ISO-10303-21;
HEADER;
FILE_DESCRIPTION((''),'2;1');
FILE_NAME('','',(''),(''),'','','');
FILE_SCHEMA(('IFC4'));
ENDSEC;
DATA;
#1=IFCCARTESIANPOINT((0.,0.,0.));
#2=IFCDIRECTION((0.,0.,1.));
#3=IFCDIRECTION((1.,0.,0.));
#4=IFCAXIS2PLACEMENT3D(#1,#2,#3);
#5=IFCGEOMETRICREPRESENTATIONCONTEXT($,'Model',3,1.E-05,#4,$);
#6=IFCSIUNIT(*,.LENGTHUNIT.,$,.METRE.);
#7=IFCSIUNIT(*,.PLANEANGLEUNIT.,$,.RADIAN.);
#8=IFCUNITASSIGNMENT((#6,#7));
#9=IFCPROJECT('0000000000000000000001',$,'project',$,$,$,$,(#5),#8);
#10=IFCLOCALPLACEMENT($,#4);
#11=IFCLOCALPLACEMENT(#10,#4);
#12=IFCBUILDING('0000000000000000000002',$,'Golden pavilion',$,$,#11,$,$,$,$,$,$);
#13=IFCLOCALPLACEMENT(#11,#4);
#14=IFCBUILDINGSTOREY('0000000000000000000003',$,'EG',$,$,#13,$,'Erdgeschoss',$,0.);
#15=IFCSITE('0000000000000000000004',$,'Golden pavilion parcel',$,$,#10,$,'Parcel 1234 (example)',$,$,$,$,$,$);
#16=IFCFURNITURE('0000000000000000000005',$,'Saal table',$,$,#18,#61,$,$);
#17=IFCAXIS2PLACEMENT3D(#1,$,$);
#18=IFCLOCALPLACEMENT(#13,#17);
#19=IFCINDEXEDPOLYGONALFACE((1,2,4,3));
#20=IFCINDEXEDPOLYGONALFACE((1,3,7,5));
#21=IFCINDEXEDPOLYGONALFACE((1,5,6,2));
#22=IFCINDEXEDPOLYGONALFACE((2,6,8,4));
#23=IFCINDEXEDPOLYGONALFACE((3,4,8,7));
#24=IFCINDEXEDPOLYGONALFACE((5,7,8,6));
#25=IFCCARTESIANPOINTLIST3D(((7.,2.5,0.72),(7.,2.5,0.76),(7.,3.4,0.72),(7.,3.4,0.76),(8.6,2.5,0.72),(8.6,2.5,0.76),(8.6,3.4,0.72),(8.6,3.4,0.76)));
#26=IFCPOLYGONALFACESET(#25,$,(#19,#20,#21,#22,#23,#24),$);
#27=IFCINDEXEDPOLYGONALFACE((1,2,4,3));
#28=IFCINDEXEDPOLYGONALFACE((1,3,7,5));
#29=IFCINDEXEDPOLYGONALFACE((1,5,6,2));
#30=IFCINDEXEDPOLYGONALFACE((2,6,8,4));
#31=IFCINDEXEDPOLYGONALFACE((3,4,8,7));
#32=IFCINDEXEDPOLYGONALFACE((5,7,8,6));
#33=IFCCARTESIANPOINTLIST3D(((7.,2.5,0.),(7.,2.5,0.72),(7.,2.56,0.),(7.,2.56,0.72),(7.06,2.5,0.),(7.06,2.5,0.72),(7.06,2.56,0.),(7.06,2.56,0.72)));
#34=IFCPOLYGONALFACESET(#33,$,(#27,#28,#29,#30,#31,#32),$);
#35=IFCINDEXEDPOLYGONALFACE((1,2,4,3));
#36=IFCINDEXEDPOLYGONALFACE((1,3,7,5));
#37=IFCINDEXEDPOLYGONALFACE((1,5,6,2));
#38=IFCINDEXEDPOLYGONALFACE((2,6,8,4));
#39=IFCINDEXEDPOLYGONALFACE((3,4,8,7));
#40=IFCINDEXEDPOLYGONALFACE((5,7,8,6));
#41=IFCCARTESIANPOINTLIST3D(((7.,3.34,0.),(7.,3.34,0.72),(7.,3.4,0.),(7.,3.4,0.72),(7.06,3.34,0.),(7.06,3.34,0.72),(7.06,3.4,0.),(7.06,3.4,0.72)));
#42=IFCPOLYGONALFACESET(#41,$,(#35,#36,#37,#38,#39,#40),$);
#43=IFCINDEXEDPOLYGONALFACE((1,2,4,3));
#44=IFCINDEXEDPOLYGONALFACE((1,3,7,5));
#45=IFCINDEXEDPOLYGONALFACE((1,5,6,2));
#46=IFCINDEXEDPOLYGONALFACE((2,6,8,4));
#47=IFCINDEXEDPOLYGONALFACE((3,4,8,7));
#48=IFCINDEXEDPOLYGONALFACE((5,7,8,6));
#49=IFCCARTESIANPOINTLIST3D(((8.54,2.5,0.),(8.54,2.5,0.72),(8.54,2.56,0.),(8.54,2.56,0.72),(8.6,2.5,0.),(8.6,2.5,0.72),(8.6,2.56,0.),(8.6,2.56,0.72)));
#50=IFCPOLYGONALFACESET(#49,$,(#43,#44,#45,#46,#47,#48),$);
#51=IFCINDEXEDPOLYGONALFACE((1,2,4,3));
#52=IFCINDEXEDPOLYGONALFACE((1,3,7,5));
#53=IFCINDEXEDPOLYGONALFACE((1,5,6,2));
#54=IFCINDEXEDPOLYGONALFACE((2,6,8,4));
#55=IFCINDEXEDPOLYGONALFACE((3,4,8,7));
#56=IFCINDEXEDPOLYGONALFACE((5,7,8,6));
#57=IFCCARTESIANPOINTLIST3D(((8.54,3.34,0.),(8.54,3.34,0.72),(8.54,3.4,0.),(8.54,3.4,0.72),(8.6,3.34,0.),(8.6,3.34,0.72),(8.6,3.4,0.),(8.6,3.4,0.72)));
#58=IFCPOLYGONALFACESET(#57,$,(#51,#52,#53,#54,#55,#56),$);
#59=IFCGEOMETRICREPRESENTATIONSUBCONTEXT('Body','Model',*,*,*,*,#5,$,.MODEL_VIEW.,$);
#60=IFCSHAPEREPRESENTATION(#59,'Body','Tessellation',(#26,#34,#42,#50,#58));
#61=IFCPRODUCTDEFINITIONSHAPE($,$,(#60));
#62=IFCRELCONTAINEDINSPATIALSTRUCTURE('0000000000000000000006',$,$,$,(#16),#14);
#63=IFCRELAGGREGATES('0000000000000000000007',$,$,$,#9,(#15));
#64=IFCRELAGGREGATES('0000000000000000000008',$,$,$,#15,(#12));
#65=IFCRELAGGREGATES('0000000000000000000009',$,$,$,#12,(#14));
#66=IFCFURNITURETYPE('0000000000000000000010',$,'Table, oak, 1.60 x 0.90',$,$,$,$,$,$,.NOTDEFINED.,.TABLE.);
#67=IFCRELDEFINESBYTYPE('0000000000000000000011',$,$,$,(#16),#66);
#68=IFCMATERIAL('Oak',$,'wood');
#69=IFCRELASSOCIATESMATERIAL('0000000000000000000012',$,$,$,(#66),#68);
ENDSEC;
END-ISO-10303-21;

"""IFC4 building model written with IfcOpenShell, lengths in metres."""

from ifc_helpers import new_model, si_unit, frame, origin_with_axes, place, context, subcontext, project, spatial, line, indexed_curve, outline, extrude, source, transform, mapped, material, type_object, type_shapes, element, save


model = new_model("IFC4")

# Units and contexts
model_context = context("Model", 3, precision=1e-05, world=origin_with_axes())
body_context = subcontext(model_context, "Body", "Model", "MODEL_VIEW")
ifc_project = project(units=[si_unit("LENGTHUNIT", "METRE"), si_unit("PLANEANGLEUNIT", "RADIAN")], contexts=[model_context])

# Site, building, storey
site_placement = place(None, origin_with_axes())
site = spatial("IfcSite", under=ifc_project, at=site_placement, Name="Golden pavilion parcel", LongName="Parcel 1234 (example)")
building_placement = place(site_placement, origin_with_axes())
building = spatial("IfcBuilding", under=site, at=building_placement, Name="Golden pavilion")
storey_placement = place(building_placement, origin_with_axes())
storey = spatial("IfcBuildingStorey", under=building, at=storey_placement, Name="EG", LongName="Erdgeschoss", Elevation=0.0)

# Shared definitions
ifc_material_1 = material(Name="Oak", Category="wood")

# Furniture
furniture_type_1 = type_object("IfcFurnitureType", Name="Table, oak, 1.60 x 0.90", AssemblyPlace="NOTDEFINED", PredefinedType="TABLE", material=ifc_material_1)
shared_shape_1 = source(origin_with_axes(), body_context, "Body", "SweptSolid", [
    extrude(outline(indexed_curve([(-0.8, -0.45), (0.8, -0.45), (0.8, 0.45), (-0.8, 0.45)], segments=[line(1, 2, 3, 4, 1)])), frame((0.0, 0.0, 0.72), z_axis=(0.0, 0.0, 1.0), x_axis=(1.0, 0.0, 0.0)), (0.0, 0.0, 1.0), 0.04),
    extrude(outline(indexed_curve([(-0.8, -0.45), (-0.74, -0.45), (-0.74, -0.39), (-0.8, -0.39)], segments=[line(1, 2, 3, 4, 1)])), origin_with_axes(), (0.0, 0.0, 1.0), 0.72),
    extrude(outline(indexed_curve([(-0.8, 0.39), (-0.74, 0.39), (-0.74, 0.45), (-0.8, 0.45)], segments=[line(1, 2, 3, 4, 1)])), origin_with_axes(), (0.0, 0.0, 1.0), 0.72),
    extrude(outline(indexed_curve([(0.74, -0.45), (0.8, -0.45), (0.8, -0.39), (0.74, -0.39)], segments=[line(1, 2, 3, 4, 1)])), origin_with_axes(), (0.0, 0.0, 1.0), 0.72),
    extrude(outline(indexed_curve([(0.74, 0.39), (0.8, 0.39), (0.8, 0.45), (0.74, 0.45)], segments=[line(1, 2, 3, 4, 1)])), origin_with_axes(), (0.0, 0.0, 1.0), 0.72),
])
type_shapes(furniture_type_1, [shared_shape_1])
furniture_placement = place(storey_placement, frame((7.8, 2.95, 0.0), z_axis=(0.0, 0.0, 1.0), x_axis=(1.0, 0.0, 0.0)))
element("IfcFurniture", 1, at=furniture_placement, inside=storey, type_object=furniture_type_1, Name="Saal table", context=body_context, shape_type="MappedRepresentation", body=[
    mapped(shared_shape_1, transform((0.0, 0.0, 0.0), x_axis=(1.0, 0.0, 0.0), y_axis=(0.0, 1.0, 0.0), z_axis=(0.0, 0.0, 1.0), scale=1.0)),
])

save(model, "model.ifc")
